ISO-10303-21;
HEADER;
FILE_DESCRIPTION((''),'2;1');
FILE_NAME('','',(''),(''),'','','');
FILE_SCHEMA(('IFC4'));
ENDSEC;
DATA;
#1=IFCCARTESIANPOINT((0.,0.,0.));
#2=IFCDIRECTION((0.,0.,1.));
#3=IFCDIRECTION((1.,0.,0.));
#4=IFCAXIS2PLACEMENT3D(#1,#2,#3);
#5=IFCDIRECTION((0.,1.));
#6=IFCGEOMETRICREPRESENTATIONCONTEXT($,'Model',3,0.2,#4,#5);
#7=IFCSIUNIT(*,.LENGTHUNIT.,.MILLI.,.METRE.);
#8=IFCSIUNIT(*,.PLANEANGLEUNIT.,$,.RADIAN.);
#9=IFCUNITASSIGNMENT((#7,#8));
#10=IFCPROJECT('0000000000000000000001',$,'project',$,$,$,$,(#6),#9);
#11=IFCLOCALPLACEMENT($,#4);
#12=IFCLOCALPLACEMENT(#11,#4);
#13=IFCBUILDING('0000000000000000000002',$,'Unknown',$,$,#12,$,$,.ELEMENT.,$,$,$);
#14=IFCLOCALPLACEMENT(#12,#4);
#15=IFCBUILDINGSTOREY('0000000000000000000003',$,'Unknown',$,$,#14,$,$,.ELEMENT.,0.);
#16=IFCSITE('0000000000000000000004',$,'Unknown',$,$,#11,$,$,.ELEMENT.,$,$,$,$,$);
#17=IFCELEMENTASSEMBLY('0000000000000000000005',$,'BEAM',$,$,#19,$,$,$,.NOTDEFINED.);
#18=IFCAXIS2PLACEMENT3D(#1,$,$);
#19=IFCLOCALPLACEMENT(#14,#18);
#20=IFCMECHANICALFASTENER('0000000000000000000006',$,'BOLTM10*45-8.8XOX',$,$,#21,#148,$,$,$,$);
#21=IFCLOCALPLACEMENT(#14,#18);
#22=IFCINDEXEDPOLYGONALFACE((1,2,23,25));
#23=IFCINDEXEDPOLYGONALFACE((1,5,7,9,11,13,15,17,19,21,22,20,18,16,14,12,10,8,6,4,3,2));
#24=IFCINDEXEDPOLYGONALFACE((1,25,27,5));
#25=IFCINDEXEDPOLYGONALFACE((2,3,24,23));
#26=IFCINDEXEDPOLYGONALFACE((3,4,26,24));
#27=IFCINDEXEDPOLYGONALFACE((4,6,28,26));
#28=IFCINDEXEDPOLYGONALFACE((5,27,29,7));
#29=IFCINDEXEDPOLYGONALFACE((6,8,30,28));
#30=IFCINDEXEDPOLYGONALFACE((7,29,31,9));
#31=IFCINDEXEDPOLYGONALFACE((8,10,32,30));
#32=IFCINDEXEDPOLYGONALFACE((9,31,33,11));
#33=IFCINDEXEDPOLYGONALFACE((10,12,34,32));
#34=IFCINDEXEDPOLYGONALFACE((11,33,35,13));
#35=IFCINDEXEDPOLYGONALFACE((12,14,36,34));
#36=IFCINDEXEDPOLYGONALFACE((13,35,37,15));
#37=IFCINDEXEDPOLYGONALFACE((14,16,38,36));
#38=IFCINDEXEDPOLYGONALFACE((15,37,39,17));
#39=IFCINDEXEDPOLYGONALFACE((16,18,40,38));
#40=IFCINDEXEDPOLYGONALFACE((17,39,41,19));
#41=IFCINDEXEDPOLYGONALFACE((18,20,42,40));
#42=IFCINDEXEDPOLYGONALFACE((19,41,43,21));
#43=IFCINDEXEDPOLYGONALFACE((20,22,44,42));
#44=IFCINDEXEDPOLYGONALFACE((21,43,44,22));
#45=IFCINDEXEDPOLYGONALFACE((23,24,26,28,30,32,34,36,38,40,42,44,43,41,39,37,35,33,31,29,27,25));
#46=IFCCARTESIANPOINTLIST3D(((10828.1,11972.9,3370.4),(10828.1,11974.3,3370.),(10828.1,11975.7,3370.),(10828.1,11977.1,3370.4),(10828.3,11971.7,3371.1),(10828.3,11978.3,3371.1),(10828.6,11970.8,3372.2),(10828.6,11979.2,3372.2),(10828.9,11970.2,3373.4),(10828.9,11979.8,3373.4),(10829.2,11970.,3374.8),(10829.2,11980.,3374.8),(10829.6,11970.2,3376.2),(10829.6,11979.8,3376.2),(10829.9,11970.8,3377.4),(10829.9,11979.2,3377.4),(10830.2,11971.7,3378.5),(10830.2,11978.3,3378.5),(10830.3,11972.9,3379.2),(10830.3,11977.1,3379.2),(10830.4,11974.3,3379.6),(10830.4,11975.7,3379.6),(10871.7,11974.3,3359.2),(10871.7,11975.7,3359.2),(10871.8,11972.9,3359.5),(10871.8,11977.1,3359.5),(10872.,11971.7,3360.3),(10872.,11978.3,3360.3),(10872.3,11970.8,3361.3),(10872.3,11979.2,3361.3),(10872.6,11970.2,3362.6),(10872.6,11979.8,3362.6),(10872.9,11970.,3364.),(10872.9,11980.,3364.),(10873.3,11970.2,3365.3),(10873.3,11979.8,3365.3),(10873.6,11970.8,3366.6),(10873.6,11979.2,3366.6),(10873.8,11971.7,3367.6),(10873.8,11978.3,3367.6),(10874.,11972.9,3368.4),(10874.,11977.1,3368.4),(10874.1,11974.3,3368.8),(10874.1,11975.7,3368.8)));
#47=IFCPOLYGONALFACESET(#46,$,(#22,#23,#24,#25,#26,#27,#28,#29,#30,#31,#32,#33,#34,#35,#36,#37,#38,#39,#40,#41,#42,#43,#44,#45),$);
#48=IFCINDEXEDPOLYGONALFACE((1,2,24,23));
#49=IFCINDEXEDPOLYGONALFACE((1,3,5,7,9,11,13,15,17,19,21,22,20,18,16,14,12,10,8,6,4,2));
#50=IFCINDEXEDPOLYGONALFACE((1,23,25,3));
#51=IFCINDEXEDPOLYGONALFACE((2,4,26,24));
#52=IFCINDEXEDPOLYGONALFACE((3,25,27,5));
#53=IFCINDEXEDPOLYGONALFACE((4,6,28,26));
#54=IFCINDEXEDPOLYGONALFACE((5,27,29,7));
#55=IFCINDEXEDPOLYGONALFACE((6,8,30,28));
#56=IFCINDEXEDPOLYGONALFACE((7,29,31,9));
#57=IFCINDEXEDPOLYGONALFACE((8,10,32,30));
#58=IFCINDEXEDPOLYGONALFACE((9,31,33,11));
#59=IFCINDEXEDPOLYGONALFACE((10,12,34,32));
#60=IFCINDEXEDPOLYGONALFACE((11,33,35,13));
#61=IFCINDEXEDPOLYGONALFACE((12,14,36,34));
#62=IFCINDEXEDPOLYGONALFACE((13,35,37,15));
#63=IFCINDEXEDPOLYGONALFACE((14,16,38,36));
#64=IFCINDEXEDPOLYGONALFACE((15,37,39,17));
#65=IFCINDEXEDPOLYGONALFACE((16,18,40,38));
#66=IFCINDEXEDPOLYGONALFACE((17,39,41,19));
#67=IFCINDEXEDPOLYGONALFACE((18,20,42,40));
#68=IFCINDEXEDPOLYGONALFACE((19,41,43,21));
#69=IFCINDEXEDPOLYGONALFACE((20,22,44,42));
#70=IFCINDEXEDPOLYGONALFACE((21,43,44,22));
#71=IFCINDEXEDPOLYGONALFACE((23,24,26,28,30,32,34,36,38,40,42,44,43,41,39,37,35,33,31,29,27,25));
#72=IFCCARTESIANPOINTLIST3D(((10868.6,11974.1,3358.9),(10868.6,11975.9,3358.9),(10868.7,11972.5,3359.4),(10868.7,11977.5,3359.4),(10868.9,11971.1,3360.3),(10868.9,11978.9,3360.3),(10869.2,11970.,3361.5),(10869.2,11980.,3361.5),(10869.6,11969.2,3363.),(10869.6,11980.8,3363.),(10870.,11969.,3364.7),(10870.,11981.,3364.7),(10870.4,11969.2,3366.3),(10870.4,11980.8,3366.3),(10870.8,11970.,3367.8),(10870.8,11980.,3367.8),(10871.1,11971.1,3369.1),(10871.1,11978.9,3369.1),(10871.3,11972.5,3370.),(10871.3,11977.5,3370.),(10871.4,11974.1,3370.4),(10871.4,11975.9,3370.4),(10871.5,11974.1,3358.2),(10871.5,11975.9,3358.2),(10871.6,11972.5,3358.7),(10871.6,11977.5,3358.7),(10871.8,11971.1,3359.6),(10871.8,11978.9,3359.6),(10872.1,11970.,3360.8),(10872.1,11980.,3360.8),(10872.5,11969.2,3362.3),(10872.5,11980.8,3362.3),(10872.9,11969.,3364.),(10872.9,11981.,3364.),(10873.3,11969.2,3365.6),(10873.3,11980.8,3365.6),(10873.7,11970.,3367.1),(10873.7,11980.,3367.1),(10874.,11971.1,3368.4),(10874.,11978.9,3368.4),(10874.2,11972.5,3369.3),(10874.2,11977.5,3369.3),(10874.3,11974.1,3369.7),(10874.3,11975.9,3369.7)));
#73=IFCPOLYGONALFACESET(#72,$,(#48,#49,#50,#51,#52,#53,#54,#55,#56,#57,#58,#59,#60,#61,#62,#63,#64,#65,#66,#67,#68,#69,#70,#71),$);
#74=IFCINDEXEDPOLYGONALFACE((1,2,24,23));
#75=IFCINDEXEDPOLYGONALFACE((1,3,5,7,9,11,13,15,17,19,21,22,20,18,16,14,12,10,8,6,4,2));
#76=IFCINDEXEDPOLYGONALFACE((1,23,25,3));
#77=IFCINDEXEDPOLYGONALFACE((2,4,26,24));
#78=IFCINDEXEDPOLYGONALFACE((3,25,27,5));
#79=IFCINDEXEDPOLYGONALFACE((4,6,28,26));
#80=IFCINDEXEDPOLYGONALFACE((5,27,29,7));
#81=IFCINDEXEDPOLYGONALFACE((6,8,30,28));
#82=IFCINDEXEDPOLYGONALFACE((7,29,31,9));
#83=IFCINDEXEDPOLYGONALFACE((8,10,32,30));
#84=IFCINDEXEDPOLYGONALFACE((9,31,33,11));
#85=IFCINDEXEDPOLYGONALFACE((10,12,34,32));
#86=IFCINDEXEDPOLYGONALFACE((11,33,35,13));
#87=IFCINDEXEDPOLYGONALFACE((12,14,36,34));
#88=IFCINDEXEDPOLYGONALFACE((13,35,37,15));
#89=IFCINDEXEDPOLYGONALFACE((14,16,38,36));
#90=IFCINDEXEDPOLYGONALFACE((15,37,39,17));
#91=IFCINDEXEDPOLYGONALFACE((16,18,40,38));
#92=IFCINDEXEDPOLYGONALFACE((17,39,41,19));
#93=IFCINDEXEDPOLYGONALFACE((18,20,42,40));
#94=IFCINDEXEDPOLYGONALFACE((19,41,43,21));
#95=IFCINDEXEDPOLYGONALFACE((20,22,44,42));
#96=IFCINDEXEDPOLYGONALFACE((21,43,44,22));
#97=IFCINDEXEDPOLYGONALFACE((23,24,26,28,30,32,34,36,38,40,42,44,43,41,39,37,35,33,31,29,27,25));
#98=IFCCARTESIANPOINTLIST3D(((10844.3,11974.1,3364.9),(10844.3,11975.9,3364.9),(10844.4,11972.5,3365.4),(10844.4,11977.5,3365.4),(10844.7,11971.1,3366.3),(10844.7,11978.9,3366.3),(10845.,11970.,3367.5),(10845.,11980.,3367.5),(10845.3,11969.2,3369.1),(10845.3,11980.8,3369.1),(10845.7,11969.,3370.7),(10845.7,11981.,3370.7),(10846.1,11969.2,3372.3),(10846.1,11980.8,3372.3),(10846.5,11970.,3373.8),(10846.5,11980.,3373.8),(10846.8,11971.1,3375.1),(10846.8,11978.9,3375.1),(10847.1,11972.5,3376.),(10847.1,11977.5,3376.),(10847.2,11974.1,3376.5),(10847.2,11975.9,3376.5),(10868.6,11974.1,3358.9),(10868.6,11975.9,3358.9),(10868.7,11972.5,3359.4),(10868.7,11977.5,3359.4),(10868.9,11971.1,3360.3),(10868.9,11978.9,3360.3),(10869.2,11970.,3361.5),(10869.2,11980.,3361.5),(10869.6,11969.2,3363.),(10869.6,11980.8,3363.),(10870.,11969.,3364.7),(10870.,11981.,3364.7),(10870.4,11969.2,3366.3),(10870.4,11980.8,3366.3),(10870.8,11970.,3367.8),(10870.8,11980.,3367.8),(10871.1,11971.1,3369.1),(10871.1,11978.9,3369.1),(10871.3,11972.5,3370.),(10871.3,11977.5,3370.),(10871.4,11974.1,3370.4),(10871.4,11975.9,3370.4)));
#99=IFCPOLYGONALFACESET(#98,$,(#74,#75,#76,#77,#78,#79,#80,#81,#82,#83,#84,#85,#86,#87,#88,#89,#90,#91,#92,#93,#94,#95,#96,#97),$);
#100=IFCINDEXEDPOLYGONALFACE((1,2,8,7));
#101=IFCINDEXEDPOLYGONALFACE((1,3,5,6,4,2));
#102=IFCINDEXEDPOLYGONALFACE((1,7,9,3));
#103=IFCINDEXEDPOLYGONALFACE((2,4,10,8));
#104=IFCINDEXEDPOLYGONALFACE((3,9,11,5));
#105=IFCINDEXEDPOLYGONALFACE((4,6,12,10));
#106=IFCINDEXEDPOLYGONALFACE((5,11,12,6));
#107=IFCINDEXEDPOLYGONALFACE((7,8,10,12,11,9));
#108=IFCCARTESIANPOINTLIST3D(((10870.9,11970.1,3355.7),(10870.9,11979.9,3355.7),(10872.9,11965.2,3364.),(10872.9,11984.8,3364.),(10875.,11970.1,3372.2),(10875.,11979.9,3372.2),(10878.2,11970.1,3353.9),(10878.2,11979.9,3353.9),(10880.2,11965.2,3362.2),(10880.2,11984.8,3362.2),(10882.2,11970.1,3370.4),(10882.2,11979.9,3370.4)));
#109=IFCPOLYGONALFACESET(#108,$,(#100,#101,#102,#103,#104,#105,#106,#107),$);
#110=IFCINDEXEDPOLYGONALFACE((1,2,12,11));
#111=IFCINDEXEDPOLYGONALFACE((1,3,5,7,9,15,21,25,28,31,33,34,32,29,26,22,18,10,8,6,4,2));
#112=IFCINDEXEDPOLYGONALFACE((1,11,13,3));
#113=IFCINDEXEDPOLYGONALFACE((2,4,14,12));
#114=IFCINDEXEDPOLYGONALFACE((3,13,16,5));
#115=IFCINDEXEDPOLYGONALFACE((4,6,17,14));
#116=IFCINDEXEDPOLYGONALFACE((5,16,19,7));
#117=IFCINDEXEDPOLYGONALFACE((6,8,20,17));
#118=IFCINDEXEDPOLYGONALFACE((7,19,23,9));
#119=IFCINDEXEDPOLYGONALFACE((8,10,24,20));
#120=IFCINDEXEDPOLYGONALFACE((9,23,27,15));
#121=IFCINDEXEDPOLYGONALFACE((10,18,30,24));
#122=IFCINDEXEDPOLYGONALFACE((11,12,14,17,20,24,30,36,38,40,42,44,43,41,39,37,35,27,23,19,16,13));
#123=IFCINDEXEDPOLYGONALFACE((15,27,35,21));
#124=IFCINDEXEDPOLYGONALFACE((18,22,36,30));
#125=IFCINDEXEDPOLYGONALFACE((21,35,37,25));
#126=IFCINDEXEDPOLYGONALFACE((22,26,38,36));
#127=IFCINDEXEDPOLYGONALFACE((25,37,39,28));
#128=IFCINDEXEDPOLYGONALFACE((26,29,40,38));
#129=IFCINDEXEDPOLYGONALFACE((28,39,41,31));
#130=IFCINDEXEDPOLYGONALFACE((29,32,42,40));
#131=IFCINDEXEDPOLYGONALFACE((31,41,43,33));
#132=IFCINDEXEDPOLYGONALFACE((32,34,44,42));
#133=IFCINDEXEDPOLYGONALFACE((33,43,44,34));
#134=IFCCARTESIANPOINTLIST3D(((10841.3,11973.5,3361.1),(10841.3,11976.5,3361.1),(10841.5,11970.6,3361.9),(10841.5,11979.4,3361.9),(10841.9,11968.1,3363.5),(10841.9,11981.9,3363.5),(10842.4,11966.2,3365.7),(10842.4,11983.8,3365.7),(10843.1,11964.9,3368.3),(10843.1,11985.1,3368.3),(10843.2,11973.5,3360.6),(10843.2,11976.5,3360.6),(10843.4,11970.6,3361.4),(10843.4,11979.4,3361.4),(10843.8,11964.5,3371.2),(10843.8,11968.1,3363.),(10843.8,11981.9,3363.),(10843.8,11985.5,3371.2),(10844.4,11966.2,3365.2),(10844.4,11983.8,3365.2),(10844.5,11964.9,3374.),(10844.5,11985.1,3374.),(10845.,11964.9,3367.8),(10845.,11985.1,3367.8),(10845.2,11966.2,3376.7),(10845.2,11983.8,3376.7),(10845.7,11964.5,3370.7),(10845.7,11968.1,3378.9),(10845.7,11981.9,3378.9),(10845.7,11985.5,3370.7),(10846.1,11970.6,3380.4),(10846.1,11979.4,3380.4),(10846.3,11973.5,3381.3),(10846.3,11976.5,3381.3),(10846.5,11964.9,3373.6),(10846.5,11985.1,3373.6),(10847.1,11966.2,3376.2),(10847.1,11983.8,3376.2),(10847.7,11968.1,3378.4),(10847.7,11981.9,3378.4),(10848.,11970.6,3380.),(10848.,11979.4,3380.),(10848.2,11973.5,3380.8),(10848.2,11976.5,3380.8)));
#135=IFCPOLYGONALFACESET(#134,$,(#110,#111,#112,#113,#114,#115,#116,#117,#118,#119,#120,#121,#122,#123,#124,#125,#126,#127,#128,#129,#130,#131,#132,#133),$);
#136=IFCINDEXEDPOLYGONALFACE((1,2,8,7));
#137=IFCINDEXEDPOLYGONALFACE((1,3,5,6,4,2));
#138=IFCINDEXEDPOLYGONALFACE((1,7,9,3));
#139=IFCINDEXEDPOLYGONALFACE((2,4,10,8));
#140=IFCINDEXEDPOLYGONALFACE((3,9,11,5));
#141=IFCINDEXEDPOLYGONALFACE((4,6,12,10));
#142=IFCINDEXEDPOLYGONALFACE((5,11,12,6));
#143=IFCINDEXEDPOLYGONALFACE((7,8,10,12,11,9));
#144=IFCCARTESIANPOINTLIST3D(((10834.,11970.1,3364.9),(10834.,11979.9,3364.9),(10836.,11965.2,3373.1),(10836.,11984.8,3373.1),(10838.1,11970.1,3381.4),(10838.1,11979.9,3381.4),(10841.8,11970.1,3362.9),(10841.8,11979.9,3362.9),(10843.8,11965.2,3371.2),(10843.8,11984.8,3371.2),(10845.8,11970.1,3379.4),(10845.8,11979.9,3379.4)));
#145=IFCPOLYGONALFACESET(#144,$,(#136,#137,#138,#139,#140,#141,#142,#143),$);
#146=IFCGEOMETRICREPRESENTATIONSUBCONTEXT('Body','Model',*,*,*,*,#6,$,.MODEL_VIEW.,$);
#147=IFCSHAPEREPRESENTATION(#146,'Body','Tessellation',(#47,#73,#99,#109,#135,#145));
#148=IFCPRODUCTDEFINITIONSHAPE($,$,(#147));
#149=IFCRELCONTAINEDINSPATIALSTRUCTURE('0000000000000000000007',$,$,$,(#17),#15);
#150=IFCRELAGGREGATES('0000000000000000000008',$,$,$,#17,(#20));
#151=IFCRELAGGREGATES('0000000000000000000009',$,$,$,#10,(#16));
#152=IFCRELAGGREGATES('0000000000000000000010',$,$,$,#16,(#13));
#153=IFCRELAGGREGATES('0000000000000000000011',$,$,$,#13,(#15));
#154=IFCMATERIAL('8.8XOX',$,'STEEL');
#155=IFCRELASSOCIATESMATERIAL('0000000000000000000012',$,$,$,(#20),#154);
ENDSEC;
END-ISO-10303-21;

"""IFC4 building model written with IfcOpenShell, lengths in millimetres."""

from ifc_helpers import new_model, si_unit, direction, frame, origin_with_axes, place, context, subcontext, project, spatial, line, arc, indexed_curve, outline, extrude, source, transform, mapped, material, element, aggregate, save


model = new_model("IFC4")

# Units and contexts
model_context = context("Model", 3, precision=0.2, world=origin_with_axes(), true_north=direction((0.0, 1.0)))
body_context = subcontext(model_context, "Body", "Model", "MODEL_VIEW")
ifc_project = project(units=[si_unit("LENGTHUNIT", "METRE", prefix="MILLI"), si_unit("PLANEANGLEUNIT", "RADIAN")], contexts=[model_context])

# Site, building, storey
site_placement = place(None, origin_with_axes())
site = spatial("IfcSite", under=ifc_project, at=site_placement, Name="Unknown", CompositionType="ELEMENT")
building_placement = place(site_placement, origin_with_axes())
building = spatial("IfcBuilding", under=site, at=building_placement, Name="Unknown", CompositionType="ELEMENT")
storey_placement = place(building_placement, origin_with_axes())
storey = spatial("IfcBuildingStorey", under=building, at=storey_placement, Name="Unknown", CompositionType="ELEMENT", Elevation=0.0)

# Shared definitions
ifc_material_1 = material(Name="8.8XOX", Category="STEEL")

# Element assembly, mechanical fastener
shared_shape_1 = source(origin_with_axes(), body_context, "Body", "SweptSolid", [
    extrude(outline(indexed_curve([(5.0, 0.0), (0.0, 5.0), (-5.0, 0.0), (0.0, -5.0)], segments=[arc(1, 2, 3), arc(3, 4, 1)])), frame((0.0, 0.0, 3.8), z_axis=(0.0, 0.0, -1.0), x_axis=(0.0, 1.0, 0.0)), (0.0, 0.0, 1.0), 45.0),
    extrude(outline(indexed_curve([(6.0, 0.0), (0.0, 6.0), (-6.0, 0.0), (0.0, -6.0)], segments=[arc(1, 2, 3), arc(3, 4, 1)])), frame((0.0, 0.0, 3.8), z_axis=(0.0, 0.0, -1.0), x_axis=(0.0, 1.0, 0.0)), (0.0, 0.0, 1.0), 3.0),
    extrude(outline(indexed_curve([(6.0, 0.0), (0.0, 6.0), (-6.0, 0.0), (0.0, -6.0)], segments=[arc(1, 2, 3), arc(3, 4, 1)])), frame((0.0, 0.0, 0.8), z_axis=(0.0, 0.0, -1.0), x_axis=(0.0, 1.0, 0.0)), (0.0, 0.0, 1.0), 25.0),
    extrude(outline(indexed_curve([(9.8, 0.0), (4.9, 8.5), (-4.9, 8.5), (-9.8, 0.0), (-4.9, -8.5), (4.9, -8.5)], segments=[line(1, 2, 3, 4, 5, 6, 1)])), frame((0.0, 0.0, 11.2), z_axis=(0.0, 0.0, -1.0), x_axis=(0.0, 1.0, 0.0)), (0.0, 0.0, 1.0), 7.5),
    extrude(outline(indexed_curve([(10.5, 0.0), (0.0, 10.5), (-10.5, 0.0), (0.0, -10.5)], segments=[arc(1, 2, 3), arc(3, 4, 1)])), frame((0.0, 0.0, -24.2), z_axis=(0.0, 0.0, -1.0), x_axis=(0.0, 1.0, 0.0)), (0.0, 0.0, 1.0), 2.0),
    extrude(outline(indexed_curve([(9.8, 0.0), (4.9, 8.5), (-4.9, 8.5), (-9.8, 0.0), (-4.9, -8.5), (4.9, -8.5)], segments=[line(1, 2, 3, 4, 5, 6, 1)])), frame((0.0, 0.0, -26.2), z_axis=(0.0, 0.0, -1.0), x_axis=(0.0, 1.0, 0.0)), (0.0, 0.0, 1.0), 8.0),
])
assembly_1_placement = place(storey_placement, frame((10859.1, 6000.0, 3372.5), z_axis=(0.970613, 0.0, -0.240648), x_axis=(0.0, 1.0, 0.0)))
assembly_1 = element("IfcElementAssembly", 1, at=assembly_1_placement, inside=storey, Name="BEAM", PredefinedType="NOTDEFINED")
mechanical_fastener_1_placement = place(assembly_1_placement, frame((5975.0, -5.0, 11.8), z_axis=(0.0, 0.0, 1.0), x_axis=(0.0, 1.0, 0.0)))
mechanical_fastener_1 = element("IfcMechanicalFastener", 2, at=mechanical_fastener_1_placement, material=ifc_material_1, Name="BOLTM10*45-8.8XOX", context=body_context, shape_type="MappedRepresentation", body=[
    mapped(shared_shape_1, transform((0.0, 0.0, 0.0))),
])
aggregate(assembly_1, [mechanical_fastener_1])

save(model, "model.ifc")
